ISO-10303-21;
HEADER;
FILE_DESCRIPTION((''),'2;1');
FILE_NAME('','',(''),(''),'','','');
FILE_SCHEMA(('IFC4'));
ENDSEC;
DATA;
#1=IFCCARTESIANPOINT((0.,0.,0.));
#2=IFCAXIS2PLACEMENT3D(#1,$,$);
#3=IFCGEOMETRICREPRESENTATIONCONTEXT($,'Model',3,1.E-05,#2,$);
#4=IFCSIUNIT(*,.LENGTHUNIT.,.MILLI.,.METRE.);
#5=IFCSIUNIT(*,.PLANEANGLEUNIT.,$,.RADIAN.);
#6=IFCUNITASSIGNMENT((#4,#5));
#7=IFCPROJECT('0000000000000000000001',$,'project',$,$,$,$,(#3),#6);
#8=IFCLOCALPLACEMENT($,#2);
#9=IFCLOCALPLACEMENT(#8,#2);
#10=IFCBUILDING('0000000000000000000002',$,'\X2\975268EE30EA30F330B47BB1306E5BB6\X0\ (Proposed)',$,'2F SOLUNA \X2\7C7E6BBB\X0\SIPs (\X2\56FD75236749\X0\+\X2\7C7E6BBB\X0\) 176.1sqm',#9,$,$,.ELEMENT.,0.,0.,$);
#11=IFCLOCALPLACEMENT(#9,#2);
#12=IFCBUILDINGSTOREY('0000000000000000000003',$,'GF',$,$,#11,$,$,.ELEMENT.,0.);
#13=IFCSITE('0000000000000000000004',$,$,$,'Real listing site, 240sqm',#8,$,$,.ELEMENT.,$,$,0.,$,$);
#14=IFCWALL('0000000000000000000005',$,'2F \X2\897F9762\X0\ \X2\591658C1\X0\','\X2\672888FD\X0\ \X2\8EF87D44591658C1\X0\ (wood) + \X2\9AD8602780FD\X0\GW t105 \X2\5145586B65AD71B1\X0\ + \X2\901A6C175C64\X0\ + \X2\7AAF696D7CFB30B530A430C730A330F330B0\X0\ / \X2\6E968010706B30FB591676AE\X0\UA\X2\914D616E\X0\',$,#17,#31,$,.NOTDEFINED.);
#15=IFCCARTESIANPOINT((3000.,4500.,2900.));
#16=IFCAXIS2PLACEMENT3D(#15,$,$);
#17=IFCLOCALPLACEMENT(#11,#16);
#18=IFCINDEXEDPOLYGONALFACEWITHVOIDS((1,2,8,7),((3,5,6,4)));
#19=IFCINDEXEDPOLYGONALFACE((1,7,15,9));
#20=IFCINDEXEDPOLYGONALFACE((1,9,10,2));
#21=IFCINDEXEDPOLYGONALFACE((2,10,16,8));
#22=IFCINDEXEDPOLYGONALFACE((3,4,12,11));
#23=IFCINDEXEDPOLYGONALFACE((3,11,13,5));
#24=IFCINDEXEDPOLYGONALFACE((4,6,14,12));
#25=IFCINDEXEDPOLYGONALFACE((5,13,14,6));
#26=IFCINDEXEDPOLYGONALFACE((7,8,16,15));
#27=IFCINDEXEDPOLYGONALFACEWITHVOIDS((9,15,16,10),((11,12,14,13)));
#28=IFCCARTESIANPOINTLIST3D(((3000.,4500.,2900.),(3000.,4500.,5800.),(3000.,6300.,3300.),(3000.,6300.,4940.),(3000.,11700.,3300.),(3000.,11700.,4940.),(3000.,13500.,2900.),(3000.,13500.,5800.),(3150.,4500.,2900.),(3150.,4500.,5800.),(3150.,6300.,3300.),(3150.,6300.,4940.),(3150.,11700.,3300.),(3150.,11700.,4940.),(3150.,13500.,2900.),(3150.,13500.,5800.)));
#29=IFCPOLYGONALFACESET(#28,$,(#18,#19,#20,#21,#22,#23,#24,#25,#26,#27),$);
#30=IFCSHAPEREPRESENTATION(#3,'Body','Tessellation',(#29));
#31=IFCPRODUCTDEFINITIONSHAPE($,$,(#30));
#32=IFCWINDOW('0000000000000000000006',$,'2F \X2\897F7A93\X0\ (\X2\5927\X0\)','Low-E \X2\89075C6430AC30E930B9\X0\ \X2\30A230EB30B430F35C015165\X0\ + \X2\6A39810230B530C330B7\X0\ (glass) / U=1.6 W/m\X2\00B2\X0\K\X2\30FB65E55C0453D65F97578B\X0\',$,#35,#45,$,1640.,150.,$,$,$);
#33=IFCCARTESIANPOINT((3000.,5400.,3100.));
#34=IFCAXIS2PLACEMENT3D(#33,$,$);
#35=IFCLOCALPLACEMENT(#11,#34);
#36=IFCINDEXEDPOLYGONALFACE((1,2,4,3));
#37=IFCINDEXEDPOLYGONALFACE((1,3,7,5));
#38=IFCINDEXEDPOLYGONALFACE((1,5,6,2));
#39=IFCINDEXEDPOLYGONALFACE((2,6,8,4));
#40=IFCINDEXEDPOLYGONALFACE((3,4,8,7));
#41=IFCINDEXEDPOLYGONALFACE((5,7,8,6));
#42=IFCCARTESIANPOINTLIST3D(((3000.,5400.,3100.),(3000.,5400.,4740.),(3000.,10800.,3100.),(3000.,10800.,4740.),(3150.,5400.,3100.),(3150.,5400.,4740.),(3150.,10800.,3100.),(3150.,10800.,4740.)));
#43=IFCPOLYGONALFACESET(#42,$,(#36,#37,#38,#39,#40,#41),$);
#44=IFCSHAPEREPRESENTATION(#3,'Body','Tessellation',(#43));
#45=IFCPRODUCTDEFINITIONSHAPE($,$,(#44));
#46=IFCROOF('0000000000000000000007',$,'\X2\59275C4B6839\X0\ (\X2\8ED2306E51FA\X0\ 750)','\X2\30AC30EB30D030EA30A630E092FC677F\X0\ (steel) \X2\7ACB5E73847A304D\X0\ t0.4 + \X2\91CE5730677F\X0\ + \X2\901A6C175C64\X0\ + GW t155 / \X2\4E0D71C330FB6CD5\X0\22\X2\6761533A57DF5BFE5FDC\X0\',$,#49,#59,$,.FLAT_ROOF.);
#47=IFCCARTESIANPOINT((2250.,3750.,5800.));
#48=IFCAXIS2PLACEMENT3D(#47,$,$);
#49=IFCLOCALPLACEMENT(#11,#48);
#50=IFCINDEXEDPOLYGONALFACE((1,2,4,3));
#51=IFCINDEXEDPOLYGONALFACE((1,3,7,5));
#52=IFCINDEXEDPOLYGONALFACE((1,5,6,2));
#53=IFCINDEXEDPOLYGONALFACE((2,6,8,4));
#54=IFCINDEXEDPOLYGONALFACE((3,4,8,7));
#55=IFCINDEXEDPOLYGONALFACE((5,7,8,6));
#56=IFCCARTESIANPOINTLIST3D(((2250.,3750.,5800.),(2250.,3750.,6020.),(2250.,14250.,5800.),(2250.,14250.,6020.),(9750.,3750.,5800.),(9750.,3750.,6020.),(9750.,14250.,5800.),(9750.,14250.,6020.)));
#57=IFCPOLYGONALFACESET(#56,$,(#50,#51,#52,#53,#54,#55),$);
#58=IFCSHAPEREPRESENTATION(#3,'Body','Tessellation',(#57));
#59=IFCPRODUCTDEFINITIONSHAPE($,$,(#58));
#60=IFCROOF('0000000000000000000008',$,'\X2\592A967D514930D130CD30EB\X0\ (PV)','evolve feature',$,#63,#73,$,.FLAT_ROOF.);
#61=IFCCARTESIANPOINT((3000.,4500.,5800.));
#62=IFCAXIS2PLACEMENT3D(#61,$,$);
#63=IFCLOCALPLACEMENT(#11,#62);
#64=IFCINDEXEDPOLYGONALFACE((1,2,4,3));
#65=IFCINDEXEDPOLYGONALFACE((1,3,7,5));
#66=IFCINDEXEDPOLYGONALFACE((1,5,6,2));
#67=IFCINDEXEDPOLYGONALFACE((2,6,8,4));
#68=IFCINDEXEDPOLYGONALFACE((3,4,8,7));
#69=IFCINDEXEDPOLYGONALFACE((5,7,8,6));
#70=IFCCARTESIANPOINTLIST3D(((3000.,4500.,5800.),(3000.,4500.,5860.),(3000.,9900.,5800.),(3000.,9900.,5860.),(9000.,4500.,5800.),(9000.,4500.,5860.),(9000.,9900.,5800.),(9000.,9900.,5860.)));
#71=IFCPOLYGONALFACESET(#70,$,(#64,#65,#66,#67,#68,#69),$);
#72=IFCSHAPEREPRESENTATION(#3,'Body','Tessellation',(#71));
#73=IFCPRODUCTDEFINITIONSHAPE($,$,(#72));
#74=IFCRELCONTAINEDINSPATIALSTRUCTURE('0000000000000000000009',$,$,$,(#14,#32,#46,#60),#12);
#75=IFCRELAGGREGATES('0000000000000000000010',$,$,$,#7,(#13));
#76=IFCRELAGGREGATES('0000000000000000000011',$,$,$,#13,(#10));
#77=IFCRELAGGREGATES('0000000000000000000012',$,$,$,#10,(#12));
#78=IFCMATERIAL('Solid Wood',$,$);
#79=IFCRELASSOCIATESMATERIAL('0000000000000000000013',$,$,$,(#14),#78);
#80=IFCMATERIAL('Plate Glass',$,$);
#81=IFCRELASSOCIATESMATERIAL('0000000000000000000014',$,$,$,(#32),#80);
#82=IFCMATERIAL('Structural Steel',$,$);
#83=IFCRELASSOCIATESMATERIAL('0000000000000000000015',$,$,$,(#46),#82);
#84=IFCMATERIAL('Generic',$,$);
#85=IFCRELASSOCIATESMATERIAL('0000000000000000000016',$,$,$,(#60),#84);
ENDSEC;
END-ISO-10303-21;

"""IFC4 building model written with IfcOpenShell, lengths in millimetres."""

from ifc_helpers import new_model, si_unit, frame, frame_2d, origin, place, context, project, spatial, rectangle, extrude, material, element, fill, save


model = new_model("IFC4")

# Units and contexts
model_context = context("Model", 3, precision=1e-05, world=origin())
ifc_project = project(units=[si_unit("LENGTHUNIT", "METRE", prefix="MILLI"), si_unit("PLANEANGLEUNIT", "RADIAN")], contexts=[model_context])

# Site, building, storey
site_placement = place(None, origin())
site = spatial("IfcSite", under=ifc_project, at=site_placement, ObjectType="Real listing site, 240sqm", CompositionType="ELEMENT", RefElevation=0.0)
building_placement = place(site_placement, origin())
building = spatial("IfcBuilding", under=site, at=building_placement, Name="青森リンゴ箱の家 (Proposed)", ObjectType="2F SOLUNA 籾殻SIPs (国産杉+籾殻) 176.1sqm", CompositionType="ELEMENT", ElevationOfRefHeight=0.0, ElevationOfTerrain=0.0)
storey_placement = place(building_placement, origin())
storey = spatial("IfcBuildingStorey", under=building, at=storey_placement, Name="GF", CompositionType="ELEMENT", Elevation=0.0)

# Shared definitions
ifc_material_1 = material(Name="Solid Wood")
ifc_material_2 = material(Name="Generic")

# Shared definitions
ifc_material_3 = material(Name="Plate Glass")

# Wall, opening, window
wall_1_placement = place(storey_placement, frame((3000.0, 4500.0, 2900.0)))
wall_1 = element("IfcWall", 1, at=wall_1_placement, inside=storey, material=ifc_material_1, Name="2F 西面 外壁", Description="木製 軸組外壁 (wood) + 高性能GW t105 充填断熱 + 通気層 + 窯業系サイディング / 準耐火・外皮UA配慮", PredefinedType="NOTDEFINED", context=model_context, shape_type="SweptSolid", body=[
    extrude(rectangle(XDim=150.0, YDim=9000.0, at=frame_2d((75.0, 4500.0))), frame((3000.0, 4500.0, 2900.0)), (0.0, 0.0, 1.0), 2900.0),
])
opening_1_placement = place(storey_placement, frame((3000.0, 5400.0, 3100.0)))
opening_1 = element("IfcOpeningElement", 2, at=opening_1_placement, cuts=wall_1, PredefinedType="NOTDEFINED", context=model_context, shape_type="SweptSolid", body=[
    extrude(rectangle(XDim=150.0, YDim=5400.0, at=frame_2d((75.0, 2700.0))), frame((3000.0, 5400.0, 3100.0)), (0.0, 0.0, 1.0), 1640.0),
])
window_1_placement = place(storey_placement, frame((3000.0, 5400.0, 3100.0)))
window_1 = element("IfcWindow", 3, at=window_1_placement, inside=storey, material=ifc_material_3, Name="2F 西窓 (大)", Description="Low-E 複層ガラス アルゴン封入 + 樹脂サッシ (glass) / U=1.6 W/m²K・日射取得型", OverallHeight=1640.0, OverallWidth=150.0, context=model_context, shape_type="SweptSolid", body=[
    extrude(rectangle(XDim=150.0, YDim=5400.0, at=frame_2d((75.0, 2700.0))), frame((3000.0, 5400.0, 3100.0)), (0.0, 0.0, 1.0), 1640.0),
])
fill(opening_1, window_1)

# Roofs
ifc_material_4 = material(Name="Structural Steel")
roof_1_placement = place(storey_placement, frame((2250.0, 3750.0, 5800.0)))
element("IfcRoof", 4, at=roof_1_placement, inside=storey, material=ifc_material_4, Name="大屋根 (軒の出 750)", Description="ガルバリウム鋼板 (steel) 立平葺き t0.4 + 野地板 + 通気層 + GW t155 / 不燃・法22条区域対応", PredefinedType="FLAT_ROOF", context=model_context, shape_type="SweptSolid", body=[
    extrude(rectangle(XDim=7500.0, YDim=10500.0, at=frame_2d((3750.0, 5250.0))), frame((2250.0, 3750.0, 5800.0)), (0.0, 0.0, 1.0), 220.0),
])
roof_2_placement = place(storey_placement, frame((3000.0, 4500.0, 5800.0)))
element("IfcRoof", 5, at=roof_2_placement, inside=storey, material=ifc_material_2, Name="太陽光パネル (PV)", Description="evolve feature", PredefinedType="FLAT_ROOF", context=model_context, shape_type="SweptSolid", body=[
    extrude(rectangle(XDim=6000.0, YDim=5400.0, at=frame_2d((3000.0, 2700.0))), frame((3000.0, 4500.0, 5800.0)), (0.0, 0.0, 1.0), 60.0),
])

save(model, "model.ifc")
